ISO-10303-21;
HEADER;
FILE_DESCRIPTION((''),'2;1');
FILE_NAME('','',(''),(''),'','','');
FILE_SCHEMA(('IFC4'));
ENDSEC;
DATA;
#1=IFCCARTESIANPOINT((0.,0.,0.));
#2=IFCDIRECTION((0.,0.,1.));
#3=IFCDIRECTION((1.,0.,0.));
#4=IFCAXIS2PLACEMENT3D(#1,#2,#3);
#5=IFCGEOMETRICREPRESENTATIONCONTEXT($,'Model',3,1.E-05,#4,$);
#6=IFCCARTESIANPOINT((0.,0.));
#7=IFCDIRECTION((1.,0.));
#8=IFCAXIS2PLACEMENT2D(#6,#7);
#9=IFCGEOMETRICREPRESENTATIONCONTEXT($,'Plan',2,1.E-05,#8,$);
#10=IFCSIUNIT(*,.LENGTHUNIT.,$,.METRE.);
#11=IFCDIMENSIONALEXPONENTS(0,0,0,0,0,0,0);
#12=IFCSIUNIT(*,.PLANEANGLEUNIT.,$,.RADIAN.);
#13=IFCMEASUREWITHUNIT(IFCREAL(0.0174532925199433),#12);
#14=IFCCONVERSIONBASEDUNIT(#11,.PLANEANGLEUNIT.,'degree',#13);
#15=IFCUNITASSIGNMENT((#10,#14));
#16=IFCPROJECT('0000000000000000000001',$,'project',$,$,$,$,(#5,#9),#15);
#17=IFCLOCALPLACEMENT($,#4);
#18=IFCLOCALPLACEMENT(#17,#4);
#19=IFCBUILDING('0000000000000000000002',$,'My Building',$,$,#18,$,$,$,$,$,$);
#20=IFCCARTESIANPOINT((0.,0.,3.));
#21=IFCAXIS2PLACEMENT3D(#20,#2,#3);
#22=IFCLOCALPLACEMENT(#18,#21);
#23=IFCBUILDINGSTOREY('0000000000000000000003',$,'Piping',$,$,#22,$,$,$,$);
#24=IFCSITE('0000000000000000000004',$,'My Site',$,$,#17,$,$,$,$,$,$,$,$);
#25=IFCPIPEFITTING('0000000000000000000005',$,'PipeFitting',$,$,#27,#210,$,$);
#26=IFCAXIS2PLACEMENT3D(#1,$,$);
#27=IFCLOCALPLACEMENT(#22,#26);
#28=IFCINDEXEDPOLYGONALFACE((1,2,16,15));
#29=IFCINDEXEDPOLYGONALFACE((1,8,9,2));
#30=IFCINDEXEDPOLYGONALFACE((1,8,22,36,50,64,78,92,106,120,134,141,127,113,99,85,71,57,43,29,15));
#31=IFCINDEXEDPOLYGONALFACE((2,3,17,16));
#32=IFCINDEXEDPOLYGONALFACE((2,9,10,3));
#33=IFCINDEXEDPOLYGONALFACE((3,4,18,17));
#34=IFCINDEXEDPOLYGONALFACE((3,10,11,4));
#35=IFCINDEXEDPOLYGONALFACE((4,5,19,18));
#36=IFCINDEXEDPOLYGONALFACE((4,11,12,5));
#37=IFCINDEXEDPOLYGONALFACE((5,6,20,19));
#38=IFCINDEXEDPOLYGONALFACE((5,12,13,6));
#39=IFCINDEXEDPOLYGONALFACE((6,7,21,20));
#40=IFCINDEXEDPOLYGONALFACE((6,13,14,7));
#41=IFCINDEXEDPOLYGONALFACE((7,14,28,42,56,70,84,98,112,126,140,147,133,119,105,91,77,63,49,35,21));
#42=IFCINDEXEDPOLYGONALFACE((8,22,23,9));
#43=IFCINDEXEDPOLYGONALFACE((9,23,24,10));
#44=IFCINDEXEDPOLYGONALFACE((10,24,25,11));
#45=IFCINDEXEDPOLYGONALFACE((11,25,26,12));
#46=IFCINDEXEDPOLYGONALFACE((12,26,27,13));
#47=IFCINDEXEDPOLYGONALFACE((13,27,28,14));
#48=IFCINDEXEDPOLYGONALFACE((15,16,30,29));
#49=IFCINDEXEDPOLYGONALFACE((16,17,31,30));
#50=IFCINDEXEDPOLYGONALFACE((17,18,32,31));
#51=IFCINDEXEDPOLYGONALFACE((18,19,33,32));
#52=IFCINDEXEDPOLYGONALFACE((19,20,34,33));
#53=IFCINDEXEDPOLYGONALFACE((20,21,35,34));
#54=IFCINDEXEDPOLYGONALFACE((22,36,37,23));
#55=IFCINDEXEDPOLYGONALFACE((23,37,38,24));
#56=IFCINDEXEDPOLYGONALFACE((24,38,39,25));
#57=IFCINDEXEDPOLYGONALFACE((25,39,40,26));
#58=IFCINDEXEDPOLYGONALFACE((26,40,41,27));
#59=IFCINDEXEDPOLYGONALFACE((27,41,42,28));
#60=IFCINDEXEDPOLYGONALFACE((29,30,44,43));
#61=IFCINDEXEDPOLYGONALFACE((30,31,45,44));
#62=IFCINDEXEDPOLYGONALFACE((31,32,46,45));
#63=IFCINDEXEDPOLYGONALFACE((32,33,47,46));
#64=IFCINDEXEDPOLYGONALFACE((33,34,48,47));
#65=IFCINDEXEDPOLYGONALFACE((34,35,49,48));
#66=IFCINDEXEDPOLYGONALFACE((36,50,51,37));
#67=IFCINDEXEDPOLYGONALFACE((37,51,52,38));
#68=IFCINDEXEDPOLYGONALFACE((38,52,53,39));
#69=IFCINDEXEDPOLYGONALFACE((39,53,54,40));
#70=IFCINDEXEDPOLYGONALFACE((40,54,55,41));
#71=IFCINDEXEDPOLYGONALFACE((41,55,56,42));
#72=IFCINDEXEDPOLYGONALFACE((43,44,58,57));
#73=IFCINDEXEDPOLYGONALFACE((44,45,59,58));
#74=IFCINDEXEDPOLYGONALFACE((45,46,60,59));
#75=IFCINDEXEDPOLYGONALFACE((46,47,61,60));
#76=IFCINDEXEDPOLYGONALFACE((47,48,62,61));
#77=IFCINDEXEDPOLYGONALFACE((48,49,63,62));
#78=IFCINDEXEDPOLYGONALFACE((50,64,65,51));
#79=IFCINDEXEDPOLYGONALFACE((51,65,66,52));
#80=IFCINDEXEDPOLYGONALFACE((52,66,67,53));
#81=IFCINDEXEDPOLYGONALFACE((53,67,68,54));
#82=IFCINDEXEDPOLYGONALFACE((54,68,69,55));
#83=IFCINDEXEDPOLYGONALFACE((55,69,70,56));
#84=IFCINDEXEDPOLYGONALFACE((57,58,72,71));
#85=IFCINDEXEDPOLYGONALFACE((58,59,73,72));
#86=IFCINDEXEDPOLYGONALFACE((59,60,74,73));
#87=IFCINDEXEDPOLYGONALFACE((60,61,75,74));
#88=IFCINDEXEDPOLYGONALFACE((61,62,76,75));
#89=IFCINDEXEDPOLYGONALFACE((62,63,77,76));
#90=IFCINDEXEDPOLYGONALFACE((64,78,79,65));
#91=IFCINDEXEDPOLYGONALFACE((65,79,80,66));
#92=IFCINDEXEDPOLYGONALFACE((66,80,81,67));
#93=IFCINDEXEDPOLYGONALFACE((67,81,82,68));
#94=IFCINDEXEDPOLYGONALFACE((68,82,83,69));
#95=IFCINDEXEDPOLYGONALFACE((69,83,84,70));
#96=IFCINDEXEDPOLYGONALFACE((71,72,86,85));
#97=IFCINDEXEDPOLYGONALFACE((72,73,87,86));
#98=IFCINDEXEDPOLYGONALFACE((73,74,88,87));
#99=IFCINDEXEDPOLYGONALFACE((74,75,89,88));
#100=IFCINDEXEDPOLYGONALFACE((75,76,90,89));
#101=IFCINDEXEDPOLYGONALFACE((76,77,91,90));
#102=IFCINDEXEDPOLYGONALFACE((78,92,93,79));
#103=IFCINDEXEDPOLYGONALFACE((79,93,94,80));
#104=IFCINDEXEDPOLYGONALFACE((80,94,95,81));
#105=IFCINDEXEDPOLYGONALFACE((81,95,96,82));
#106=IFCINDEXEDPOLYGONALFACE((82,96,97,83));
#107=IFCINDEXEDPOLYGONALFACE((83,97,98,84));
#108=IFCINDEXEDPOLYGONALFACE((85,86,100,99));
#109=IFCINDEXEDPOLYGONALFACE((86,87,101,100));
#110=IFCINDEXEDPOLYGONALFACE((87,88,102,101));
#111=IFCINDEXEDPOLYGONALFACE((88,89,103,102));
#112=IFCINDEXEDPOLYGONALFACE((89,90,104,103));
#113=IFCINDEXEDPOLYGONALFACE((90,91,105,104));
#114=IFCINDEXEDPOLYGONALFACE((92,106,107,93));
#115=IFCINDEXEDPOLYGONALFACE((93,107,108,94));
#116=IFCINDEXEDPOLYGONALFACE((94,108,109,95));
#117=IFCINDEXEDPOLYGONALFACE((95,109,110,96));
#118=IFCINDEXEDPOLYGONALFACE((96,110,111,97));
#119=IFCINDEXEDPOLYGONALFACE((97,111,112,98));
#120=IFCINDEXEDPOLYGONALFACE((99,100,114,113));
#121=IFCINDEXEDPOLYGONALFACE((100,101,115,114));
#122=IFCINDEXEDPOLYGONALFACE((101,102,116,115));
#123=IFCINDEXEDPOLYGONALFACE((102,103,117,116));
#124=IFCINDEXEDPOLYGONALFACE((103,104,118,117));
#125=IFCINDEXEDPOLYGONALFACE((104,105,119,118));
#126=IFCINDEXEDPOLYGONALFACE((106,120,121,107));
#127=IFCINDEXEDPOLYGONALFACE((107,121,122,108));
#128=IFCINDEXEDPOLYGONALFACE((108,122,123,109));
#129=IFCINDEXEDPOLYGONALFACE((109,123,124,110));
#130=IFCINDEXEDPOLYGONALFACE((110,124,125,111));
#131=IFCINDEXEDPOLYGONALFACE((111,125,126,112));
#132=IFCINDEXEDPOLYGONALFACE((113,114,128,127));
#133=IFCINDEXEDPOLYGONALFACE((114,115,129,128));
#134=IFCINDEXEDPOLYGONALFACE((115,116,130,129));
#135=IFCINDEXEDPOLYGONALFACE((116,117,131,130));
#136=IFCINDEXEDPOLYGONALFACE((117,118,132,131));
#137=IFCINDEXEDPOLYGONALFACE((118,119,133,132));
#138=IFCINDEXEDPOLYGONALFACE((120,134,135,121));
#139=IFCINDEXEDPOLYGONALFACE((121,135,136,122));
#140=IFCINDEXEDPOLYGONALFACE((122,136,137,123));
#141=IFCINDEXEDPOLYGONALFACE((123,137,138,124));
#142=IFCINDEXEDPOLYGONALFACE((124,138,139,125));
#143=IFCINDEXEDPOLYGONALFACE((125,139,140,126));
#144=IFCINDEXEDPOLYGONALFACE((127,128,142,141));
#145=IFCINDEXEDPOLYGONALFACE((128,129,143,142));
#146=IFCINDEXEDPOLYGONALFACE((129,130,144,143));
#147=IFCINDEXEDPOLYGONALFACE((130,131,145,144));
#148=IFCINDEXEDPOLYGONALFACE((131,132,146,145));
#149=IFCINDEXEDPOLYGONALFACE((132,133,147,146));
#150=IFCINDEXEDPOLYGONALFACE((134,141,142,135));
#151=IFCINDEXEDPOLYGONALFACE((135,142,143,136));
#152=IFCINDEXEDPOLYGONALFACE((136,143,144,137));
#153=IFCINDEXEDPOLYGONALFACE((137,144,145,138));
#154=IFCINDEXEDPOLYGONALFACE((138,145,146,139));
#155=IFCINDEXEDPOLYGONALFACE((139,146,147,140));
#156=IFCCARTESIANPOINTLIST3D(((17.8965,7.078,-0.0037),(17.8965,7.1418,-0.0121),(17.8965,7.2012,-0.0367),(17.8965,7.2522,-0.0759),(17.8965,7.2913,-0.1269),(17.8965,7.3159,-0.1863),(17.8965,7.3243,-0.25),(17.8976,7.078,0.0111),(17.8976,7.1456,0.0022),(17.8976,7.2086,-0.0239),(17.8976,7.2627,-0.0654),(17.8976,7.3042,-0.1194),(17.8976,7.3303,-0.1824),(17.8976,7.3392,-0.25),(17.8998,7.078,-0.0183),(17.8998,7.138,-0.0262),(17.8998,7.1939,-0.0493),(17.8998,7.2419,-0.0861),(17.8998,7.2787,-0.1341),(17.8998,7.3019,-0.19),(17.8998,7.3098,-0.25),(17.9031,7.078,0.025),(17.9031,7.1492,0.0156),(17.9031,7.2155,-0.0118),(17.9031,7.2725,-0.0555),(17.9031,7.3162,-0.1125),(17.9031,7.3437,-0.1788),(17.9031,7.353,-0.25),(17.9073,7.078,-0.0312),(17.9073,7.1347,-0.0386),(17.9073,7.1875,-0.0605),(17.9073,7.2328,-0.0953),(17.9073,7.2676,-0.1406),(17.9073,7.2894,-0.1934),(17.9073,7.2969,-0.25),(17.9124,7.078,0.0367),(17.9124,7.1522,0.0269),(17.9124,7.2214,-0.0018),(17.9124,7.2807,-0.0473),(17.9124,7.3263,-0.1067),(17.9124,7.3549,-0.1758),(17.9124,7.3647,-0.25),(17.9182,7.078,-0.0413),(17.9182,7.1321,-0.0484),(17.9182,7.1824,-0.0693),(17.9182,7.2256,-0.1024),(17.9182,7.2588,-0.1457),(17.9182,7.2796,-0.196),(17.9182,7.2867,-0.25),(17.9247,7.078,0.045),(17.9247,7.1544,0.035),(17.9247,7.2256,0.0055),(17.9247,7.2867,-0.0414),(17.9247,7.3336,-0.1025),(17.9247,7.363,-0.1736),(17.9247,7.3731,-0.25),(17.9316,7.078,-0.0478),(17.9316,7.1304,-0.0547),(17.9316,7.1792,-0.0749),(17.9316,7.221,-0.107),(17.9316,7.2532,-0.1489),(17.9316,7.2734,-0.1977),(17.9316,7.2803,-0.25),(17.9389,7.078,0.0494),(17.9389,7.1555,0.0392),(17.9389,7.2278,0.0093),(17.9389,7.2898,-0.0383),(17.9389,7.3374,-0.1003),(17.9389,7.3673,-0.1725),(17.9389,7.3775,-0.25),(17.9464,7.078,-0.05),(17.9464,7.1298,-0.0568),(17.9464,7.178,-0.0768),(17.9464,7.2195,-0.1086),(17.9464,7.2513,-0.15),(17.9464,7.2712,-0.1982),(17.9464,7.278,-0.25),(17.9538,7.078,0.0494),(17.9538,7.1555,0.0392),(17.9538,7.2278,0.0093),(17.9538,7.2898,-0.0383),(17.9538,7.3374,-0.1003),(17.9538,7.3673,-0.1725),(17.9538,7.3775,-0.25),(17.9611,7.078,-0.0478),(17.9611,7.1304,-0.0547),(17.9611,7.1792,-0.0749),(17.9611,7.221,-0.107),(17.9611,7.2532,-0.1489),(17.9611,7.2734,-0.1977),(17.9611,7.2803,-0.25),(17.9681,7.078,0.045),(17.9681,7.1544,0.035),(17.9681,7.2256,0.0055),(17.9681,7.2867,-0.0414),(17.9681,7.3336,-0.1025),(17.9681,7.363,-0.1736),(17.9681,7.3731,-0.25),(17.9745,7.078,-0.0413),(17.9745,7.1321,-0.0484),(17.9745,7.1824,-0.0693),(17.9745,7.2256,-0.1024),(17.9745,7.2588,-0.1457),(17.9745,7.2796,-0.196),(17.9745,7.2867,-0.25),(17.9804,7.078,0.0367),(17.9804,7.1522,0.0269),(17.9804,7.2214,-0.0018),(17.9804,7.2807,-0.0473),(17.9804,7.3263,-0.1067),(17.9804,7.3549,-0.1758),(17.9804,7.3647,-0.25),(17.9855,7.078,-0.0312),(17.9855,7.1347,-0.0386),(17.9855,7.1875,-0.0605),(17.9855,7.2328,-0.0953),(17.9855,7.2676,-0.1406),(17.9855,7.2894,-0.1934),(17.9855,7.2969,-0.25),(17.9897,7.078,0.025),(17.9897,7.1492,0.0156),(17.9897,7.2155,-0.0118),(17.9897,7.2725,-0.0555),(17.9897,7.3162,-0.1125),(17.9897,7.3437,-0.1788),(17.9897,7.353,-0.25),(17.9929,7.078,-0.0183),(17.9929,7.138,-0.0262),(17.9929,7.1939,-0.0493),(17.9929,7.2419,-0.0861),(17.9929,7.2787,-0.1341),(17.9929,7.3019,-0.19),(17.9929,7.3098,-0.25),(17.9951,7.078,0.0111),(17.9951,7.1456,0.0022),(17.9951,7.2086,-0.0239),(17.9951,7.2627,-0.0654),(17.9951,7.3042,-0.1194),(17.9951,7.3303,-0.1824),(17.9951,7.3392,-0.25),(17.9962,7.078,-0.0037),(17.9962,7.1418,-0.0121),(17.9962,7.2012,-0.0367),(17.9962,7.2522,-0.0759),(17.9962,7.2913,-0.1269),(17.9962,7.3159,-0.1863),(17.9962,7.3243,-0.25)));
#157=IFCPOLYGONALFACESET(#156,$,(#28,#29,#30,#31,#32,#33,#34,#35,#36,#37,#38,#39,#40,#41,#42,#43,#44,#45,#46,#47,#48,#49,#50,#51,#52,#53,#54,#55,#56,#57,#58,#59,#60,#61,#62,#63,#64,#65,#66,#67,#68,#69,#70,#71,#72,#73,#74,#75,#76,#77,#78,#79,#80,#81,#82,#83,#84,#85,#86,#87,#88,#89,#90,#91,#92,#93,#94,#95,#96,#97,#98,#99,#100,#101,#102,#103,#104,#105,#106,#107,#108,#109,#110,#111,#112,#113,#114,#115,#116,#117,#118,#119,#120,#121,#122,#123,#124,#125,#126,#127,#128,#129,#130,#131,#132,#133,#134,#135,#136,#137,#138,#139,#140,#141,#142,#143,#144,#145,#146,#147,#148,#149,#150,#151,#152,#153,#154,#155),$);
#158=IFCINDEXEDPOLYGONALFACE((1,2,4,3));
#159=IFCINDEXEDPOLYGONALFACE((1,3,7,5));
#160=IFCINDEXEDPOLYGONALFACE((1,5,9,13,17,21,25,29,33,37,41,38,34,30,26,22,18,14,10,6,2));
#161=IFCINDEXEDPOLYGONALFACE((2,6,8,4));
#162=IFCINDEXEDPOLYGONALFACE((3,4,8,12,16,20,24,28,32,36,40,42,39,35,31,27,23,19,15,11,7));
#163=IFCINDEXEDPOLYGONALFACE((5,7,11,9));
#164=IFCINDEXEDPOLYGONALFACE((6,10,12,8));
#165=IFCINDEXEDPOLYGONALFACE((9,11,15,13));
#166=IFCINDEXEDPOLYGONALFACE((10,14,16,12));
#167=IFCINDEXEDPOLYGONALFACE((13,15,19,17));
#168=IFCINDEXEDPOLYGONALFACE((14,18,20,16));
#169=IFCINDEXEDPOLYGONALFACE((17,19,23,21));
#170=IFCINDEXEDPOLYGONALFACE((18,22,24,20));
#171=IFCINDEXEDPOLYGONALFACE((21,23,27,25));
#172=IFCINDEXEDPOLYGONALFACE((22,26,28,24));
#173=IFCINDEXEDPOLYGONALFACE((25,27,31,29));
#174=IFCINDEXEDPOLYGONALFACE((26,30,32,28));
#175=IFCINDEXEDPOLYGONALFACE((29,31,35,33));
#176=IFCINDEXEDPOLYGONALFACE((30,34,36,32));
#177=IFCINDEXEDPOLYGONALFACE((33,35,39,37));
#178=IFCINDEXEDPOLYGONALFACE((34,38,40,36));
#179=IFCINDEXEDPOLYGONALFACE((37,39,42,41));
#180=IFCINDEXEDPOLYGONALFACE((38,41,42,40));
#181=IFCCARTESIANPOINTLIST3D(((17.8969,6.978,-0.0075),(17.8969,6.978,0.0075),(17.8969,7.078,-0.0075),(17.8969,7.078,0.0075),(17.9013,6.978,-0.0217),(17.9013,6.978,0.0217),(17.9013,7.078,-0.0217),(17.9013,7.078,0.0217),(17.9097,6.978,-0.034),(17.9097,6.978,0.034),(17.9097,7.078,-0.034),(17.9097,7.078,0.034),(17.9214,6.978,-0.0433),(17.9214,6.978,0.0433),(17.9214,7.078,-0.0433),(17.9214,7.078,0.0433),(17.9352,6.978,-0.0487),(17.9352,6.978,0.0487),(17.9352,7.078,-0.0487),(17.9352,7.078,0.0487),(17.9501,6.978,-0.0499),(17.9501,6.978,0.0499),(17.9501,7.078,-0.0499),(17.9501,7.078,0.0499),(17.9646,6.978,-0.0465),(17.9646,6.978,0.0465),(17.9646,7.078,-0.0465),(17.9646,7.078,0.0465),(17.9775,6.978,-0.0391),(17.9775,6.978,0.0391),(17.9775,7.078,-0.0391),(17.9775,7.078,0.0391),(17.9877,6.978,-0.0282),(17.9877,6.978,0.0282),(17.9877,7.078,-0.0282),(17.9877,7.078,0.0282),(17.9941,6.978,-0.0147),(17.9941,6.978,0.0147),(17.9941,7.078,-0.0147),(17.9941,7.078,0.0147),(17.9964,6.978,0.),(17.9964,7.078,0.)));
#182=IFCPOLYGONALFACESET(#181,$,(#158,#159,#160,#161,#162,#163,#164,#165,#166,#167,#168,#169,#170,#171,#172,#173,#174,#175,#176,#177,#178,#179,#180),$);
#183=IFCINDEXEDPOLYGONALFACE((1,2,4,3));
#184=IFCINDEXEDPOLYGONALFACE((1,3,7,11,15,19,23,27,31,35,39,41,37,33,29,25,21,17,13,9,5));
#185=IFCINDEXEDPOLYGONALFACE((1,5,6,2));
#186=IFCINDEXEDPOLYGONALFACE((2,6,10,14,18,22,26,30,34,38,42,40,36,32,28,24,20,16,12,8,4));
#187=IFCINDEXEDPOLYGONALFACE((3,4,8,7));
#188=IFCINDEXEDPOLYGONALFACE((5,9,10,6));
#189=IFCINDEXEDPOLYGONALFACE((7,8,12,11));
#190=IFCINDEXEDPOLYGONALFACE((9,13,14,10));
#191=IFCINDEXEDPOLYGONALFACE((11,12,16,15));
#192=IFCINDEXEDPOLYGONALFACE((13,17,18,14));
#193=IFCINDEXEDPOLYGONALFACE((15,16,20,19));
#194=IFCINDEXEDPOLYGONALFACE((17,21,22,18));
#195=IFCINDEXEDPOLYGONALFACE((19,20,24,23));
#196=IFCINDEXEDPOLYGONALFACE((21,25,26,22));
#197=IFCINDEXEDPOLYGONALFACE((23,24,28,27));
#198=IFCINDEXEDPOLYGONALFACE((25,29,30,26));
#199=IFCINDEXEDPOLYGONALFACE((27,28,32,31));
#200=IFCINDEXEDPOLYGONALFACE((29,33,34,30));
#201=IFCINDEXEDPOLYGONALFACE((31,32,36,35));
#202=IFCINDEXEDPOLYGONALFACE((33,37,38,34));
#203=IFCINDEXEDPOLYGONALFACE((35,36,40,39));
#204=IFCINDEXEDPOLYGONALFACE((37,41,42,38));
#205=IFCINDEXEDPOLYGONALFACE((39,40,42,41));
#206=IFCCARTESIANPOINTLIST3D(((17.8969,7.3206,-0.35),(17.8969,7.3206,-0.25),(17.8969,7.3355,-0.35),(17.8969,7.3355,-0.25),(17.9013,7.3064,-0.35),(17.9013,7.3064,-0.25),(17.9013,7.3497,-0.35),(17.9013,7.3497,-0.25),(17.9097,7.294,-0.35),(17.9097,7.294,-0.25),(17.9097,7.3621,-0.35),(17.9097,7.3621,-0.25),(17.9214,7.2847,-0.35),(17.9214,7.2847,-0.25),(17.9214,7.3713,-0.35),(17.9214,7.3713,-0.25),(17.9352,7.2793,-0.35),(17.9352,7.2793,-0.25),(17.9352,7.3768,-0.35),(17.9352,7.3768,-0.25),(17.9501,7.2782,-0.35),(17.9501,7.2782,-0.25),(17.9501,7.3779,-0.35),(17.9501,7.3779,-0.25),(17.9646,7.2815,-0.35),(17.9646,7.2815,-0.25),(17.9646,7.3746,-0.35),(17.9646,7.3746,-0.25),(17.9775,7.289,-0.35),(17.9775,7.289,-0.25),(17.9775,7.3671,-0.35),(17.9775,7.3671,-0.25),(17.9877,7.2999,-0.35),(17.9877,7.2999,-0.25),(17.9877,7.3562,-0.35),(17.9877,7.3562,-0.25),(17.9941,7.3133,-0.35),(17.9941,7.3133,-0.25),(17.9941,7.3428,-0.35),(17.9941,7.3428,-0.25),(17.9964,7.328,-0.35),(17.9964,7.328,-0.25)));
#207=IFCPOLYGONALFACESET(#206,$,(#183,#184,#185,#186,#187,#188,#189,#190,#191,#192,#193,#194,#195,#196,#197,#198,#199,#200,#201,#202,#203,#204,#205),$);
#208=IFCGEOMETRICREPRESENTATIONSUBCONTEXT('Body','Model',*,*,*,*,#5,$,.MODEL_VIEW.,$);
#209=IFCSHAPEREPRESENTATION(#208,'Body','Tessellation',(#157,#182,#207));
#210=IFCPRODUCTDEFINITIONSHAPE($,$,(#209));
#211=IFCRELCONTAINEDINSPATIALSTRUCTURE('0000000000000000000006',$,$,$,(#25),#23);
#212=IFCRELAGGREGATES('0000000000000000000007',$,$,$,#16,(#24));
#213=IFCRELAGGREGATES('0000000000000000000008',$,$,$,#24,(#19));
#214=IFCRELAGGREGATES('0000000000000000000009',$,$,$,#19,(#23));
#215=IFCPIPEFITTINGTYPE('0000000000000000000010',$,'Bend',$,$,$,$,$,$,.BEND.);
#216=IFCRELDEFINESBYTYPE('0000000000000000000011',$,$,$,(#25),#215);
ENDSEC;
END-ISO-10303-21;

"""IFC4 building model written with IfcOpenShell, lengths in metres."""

from ifc_helpers import new_model, entity, si_unit, converted_unit, frame, origin_with_axes, origin_2d_with_axis, place, context, subcontext, project, spatial, circle, extrude, source, transform, mapped, type_object, type_shapes, element, save


model = new_model("IFC4")

# Units and contexts
model_context = context("Model", 3, precision=1e-05, world=origin_with_axes())
plan_context = context("Plan", 2, precision=1e-05, world=origin_2d_with_axis())
body_context = subcontext(model_context, "Body", "Model", "MODEL_VIEW")
ifc_project = project(units=[si_unit("LENGTHUNIT", "METRE"), converted_unit("PLANEANGLEUNIT", "degree", entity("IfcReal", 0.0174532925199433), si_unit("PLANEANGLEUNIT", "RADIAN"), dimensions=[0, 0, 0, 0, 0, 0, 0])], contexts=[model_context, plan_context])

# Site, building, storey
site_placement = place(None, origin_with_axes())
site = spatial("IfcSite", under=ifc_project, at=site_placement, Name="My Site")
building_placement = place(site_placement, origin_with_axes())
building = spatial("IfcBuilding", under=site, at=building_placement, Name="My Building")
storey_placement = place(building_placement, frame((0.0, 0.0, 3.0), z_axis=(0.0, 0.0, 1.0), x_axis=(1.0, 0.0, 0.0)))
storey = spatial("IfcBuildingStorey", under=building, at=storey_placement, Name="Piping")

# Pipe fitting
pipe_fitting_type_1 = type_object("IfcPipeFittingType", Name="Bend", PredefinedType="BEND")
shared_shape = source(origin_with_axes(), body_context, "Body", "SolidModel", [
    entity("IfcSweptDiskSolid", entity("IfcIndexedPolyCurve", entity("IfcCartesianPointList3D", [[0.0, 0.0, -0.1], [0.0, -0.0732, -0.2768], [0.0, -0.25, -0.35]]), [entity("IfcArcIndex", [1, 2, 3])]), 0.05),
    extrude(circle(Radius=0.05), origin_with_axes(), (0.0, 0.0, -1.0), 0.1),
    extrude(circle(Radius=0.05), frame((0.0, -0.25, -0.35), z_axis=(0.0, -1.0, 0.0), x_axis=(1.0, 0.0, 0.0)), (0.0, 0.0, 1.0), 0.1),
])
type_shapes(pipe_fitting_type_1, [shared_shape])
for number, where, z_axis, x_axis, name in (
    (1, (17.9464, 6.978, 0.0), (0.0, -1.0, 0.0), (1.0, 0.0, 0.0), "PipeFitting"),
):
    element("IfcPipeFitting", number, at=place(storey_placement, frame(where, z_axis=z_axis, x_axis=x_axis)), inside=storey, type_object=pipe_fitting_type_1, Name=name, context=body_context, shape_type="MappedRepresentation", body=[
        mapped(shared_shape, transform((0.0, 0.0, 0.0), x_axis=(1.0, 0.0, 0.0), y_axis=(0.0, 1.0, 0.0), z_axis=(0.0, 0.0, 1.0), scale=1.0)),
    ])

save(model, "model.ifc")
